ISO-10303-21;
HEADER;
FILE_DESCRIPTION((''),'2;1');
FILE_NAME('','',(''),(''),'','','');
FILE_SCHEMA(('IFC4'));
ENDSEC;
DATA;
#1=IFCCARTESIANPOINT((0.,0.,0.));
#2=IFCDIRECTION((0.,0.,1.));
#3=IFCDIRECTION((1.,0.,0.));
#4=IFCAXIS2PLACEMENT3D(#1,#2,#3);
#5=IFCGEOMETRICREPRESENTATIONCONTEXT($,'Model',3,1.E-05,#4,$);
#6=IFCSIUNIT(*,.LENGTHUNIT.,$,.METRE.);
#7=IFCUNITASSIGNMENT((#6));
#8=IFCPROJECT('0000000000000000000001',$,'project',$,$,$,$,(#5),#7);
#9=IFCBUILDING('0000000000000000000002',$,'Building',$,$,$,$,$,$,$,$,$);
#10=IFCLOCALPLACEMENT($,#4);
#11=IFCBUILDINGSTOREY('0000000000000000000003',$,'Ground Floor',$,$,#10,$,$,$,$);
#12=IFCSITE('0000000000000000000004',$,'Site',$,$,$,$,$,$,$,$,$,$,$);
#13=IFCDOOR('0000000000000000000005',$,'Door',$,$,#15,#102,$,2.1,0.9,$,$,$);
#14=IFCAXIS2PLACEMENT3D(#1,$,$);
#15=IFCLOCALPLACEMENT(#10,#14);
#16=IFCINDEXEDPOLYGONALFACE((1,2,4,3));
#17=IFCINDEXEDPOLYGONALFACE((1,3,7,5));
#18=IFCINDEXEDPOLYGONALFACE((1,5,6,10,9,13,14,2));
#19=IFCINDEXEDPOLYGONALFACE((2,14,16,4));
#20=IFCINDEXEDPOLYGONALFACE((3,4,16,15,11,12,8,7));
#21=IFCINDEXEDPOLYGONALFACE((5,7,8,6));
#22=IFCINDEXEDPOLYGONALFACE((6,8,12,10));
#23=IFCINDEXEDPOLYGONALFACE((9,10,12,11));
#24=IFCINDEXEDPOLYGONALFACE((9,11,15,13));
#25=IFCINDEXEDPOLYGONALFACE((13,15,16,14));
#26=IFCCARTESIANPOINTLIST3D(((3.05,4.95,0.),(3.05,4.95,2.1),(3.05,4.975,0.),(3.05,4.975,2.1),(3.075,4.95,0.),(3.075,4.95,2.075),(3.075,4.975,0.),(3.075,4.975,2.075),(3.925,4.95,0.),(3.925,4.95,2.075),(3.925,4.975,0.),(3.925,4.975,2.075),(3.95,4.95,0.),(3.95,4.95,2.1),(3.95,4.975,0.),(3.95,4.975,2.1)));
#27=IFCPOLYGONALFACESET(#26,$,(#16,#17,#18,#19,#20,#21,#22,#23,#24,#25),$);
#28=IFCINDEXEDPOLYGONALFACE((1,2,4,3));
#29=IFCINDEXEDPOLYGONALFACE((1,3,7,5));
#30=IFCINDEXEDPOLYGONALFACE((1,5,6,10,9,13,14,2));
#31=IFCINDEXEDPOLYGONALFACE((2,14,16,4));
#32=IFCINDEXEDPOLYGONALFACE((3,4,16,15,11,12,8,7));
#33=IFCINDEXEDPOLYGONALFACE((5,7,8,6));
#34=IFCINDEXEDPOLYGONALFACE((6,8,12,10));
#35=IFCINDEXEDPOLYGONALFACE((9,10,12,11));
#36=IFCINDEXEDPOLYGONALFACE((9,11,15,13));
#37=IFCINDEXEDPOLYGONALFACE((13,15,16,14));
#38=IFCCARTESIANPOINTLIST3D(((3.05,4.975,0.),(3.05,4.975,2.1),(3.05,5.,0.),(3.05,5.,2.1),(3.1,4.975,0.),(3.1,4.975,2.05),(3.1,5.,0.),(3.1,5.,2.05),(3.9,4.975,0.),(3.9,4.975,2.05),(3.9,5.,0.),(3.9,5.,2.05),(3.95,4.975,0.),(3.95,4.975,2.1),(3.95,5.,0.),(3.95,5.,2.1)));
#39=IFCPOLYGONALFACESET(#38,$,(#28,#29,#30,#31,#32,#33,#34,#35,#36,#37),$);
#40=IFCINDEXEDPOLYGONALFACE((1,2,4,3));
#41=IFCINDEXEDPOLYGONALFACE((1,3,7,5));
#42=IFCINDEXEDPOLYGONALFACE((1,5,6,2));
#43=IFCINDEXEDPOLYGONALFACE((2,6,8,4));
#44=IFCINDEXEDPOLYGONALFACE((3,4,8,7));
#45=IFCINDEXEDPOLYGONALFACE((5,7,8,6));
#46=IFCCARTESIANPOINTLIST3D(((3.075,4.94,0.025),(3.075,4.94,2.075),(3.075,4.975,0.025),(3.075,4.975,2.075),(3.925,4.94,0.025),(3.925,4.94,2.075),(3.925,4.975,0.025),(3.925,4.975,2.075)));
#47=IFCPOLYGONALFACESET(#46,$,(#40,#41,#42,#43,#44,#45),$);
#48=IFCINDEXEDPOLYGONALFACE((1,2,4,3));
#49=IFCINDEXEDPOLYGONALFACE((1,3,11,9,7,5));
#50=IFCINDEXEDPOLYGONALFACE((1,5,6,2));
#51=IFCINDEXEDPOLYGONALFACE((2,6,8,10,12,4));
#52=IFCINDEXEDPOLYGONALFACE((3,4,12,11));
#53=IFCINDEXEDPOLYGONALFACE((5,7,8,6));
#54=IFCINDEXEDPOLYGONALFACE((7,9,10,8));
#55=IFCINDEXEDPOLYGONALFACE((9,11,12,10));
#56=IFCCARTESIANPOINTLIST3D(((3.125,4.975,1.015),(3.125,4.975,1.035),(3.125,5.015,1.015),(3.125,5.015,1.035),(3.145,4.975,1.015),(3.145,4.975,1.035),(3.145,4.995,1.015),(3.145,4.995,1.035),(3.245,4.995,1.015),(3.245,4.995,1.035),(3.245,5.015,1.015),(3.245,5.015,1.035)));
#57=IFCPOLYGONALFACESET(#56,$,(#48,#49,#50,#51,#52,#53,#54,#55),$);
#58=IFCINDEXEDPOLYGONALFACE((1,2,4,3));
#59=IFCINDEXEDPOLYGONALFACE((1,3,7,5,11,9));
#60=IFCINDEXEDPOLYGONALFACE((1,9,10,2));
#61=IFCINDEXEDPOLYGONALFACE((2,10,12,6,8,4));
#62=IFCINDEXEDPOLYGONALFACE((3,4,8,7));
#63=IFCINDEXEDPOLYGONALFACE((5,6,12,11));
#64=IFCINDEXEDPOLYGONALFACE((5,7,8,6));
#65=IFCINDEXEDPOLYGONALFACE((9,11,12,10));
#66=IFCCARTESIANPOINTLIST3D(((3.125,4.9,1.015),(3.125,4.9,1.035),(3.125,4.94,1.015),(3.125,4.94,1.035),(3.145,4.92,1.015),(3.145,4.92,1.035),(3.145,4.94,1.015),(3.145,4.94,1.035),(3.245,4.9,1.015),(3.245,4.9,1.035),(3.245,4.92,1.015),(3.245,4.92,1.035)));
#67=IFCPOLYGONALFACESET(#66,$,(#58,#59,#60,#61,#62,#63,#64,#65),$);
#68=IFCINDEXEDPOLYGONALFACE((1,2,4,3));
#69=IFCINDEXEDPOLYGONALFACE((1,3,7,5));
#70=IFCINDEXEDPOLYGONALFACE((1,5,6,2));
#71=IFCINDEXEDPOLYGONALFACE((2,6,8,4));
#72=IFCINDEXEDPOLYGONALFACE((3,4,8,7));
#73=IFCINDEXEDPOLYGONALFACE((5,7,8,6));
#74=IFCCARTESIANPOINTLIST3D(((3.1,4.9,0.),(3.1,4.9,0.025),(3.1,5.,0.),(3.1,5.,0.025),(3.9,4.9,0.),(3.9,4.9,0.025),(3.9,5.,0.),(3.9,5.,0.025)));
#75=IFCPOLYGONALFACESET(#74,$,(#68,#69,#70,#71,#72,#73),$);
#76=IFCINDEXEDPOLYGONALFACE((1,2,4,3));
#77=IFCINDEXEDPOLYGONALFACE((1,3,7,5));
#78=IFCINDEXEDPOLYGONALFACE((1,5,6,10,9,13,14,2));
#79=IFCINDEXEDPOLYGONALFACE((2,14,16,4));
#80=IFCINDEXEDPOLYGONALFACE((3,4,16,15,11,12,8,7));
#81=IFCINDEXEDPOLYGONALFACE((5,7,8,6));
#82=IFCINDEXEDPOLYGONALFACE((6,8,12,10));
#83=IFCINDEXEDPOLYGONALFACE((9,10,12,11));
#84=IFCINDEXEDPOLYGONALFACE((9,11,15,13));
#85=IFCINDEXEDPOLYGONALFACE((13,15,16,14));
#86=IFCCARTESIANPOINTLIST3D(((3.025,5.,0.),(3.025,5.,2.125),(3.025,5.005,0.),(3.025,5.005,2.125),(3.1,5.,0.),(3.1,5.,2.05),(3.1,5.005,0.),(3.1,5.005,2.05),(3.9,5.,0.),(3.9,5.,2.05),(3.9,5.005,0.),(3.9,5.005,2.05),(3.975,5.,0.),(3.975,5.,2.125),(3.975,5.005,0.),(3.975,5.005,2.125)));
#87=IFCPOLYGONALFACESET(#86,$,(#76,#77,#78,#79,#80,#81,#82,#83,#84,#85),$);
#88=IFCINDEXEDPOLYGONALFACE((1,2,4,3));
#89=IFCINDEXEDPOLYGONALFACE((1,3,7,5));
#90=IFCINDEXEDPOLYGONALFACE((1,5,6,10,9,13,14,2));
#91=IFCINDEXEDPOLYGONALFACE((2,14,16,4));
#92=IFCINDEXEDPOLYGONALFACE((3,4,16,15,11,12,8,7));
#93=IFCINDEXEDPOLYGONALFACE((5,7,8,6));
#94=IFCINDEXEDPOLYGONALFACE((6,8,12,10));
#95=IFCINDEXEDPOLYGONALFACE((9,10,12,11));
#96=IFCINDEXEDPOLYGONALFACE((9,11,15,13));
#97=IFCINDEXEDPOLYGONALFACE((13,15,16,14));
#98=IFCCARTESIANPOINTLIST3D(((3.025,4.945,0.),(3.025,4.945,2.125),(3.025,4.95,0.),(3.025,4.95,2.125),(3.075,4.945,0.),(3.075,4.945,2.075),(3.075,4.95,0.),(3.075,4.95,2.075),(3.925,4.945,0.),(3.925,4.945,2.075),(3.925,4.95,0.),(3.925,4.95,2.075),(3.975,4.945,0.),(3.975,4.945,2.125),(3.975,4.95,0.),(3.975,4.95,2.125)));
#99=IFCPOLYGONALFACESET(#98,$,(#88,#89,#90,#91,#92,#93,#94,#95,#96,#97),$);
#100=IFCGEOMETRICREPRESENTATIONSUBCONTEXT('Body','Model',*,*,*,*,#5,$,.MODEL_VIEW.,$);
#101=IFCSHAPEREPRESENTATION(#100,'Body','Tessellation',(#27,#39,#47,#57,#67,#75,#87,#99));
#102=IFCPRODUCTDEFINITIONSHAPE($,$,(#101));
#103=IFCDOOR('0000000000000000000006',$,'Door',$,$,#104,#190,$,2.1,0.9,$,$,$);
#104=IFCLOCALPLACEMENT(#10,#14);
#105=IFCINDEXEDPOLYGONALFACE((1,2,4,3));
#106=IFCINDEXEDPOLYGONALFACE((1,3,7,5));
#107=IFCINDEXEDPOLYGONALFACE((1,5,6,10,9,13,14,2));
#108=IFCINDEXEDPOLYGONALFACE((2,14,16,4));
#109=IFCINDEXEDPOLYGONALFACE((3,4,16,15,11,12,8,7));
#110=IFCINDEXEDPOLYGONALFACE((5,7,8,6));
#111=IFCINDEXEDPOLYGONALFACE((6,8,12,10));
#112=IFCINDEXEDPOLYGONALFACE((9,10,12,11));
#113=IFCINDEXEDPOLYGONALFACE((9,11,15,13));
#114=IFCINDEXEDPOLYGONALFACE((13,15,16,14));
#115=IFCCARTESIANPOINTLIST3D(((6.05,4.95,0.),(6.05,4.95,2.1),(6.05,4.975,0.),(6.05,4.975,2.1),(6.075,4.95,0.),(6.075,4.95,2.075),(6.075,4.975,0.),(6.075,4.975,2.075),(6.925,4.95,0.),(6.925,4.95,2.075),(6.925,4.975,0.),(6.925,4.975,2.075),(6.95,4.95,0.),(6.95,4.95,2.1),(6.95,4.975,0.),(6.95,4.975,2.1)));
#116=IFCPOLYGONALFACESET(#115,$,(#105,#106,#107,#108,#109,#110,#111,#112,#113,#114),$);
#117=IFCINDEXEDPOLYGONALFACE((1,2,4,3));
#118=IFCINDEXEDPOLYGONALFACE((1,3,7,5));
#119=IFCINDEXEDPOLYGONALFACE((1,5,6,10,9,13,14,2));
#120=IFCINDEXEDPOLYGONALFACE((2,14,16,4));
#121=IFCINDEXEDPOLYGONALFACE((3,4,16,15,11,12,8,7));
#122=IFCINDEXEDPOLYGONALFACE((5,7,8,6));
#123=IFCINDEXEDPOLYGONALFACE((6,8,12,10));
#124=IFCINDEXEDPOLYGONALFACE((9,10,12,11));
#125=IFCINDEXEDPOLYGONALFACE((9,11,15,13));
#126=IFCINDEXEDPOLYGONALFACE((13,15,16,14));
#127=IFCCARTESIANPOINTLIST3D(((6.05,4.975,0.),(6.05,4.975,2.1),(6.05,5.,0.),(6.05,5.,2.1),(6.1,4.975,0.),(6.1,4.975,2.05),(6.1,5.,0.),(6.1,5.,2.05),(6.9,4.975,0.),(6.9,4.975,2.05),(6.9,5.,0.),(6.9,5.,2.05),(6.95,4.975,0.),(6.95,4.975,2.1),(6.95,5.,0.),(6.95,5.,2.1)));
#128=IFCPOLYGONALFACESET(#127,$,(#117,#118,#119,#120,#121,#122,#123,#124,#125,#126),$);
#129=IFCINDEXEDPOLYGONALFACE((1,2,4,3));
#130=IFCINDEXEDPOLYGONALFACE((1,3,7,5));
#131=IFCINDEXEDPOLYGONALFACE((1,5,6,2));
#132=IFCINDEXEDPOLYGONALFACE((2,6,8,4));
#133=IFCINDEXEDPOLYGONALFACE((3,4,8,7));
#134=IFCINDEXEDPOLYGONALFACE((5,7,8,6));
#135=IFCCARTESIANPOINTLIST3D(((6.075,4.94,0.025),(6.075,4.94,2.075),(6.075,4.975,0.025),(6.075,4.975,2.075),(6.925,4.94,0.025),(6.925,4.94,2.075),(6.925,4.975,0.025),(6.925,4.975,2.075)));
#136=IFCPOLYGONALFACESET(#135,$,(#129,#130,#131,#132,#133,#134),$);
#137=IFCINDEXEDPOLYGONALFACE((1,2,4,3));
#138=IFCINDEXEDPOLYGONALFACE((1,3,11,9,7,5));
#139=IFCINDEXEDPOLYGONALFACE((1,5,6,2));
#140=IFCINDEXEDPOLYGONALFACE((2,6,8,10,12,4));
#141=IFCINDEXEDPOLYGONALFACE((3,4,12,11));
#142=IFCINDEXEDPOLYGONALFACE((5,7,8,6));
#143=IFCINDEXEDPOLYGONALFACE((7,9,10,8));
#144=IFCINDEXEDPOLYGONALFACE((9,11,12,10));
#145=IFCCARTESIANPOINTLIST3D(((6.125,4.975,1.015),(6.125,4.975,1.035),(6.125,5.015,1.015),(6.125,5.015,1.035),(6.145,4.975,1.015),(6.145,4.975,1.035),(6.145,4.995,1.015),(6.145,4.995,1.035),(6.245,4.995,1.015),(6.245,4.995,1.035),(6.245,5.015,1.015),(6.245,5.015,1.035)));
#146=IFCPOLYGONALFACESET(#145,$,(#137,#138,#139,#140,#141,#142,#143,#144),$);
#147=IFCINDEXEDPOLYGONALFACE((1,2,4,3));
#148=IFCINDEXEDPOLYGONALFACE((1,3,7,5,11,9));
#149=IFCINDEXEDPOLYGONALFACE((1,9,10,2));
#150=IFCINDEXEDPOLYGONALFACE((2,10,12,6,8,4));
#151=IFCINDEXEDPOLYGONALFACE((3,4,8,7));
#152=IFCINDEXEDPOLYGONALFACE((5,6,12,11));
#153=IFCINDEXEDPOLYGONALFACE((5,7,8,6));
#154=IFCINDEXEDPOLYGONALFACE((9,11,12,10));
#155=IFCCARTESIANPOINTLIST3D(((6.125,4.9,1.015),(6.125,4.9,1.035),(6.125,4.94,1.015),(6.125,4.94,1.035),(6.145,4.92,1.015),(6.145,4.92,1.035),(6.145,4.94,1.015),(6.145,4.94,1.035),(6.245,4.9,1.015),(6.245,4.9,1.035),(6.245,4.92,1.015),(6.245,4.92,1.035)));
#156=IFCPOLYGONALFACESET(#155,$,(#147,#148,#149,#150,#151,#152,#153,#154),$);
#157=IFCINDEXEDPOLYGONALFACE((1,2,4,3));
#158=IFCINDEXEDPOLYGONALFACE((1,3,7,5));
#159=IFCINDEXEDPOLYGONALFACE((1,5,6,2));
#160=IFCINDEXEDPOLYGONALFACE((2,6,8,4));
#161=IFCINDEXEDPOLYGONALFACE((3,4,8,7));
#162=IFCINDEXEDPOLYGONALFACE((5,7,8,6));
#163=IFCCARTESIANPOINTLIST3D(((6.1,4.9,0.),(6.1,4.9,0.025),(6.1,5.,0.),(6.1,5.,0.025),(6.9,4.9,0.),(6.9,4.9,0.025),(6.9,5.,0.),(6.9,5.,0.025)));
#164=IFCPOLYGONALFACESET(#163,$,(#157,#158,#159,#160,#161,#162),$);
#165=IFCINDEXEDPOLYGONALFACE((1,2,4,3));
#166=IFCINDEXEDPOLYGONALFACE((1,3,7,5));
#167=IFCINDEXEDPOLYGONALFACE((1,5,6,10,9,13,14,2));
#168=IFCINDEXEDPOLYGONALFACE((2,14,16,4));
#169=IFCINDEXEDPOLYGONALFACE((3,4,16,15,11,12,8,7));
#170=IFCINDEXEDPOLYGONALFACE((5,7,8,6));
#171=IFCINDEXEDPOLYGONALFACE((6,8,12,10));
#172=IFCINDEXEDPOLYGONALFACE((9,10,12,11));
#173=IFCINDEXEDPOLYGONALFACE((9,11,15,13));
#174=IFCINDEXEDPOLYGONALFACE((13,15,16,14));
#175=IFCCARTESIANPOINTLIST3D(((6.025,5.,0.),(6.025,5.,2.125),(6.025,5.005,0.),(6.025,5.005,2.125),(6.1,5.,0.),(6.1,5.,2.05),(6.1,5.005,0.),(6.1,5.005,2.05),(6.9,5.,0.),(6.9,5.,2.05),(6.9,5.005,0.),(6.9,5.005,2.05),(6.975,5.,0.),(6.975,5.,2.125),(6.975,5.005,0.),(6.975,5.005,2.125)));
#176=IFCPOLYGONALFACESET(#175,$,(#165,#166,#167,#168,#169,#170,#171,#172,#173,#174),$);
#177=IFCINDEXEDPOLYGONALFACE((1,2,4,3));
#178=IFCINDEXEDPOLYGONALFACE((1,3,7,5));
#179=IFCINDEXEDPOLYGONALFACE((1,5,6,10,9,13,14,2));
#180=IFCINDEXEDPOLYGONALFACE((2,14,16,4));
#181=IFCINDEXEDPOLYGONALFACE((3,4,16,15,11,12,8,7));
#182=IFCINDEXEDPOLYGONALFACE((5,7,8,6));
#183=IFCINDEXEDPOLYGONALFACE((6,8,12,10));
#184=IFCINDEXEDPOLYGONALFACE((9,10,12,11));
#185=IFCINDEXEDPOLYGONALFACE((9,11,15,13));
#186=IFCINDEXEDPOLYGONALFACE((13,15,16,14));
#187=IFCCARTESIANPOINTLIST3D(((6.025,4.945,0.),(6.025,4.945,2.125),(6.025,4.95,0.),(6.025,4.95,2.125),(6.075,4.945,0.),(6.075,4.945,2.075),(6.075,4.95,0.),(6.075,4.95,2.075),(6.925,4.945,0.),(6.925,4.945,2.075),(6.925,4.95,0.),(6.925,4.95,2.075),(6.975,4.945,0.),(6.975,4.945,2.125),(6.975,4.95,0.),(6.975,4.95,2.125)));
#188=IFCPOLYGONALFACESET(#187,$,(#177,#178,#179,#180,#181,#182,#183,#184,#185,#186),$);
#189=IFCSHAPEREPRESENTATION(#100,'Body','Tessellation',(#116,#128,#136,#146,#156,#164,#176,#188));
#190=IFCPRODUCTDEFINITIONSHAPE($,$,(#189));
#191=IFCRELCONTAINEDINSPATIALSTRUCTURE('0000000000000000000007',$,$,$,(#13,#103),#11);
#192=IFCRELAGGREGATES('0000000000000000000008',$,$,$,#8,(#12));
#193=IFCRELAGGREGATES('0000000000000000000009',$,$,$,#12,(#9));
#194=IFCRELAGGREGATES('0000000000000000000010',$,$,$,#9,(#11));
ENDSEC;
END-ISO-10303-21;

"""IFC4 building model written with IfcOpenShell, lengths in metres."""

from ifc_helpers import new_model, si_unit, frame, origin_with_axes, place, context, subcontext, project, spatial, line, indexed_curve, outline, extrude, element, save


model = new_model("IFC4")

# Units and contexts
model_context = context("Model", 3, precision=1e-05, world=origin_with_axes())
body_context = subcontext(model_context, "Body", "Model", "MODEL_VIEW")
ifc_project = project(units=[si_unit("LENGTHUNIT", "METRE")], contexts=[model_context])

# Site, building, storey
site = spatial("IfcSite", under=ifc_project, Name="Site")
building = spatial("IfcBuilding", under=site, Name="Building")
storey_placement = place(None, origin_with_axes())
storey = spatial("IfcBuildingStorey", under=building, at=storey_placement, Name="Ground Floor")

# Doors
door_1_placement = place(storey_placement, frame((3.95, 5.0, 0.0), z_axis=(0.0, 0.0, 1.0), x_axis=(-1.0, 0.0, 0.0)))
element("IfcDoor", 1, at=door_1_placement, inside=storey, Name="Door", OverallHeight=2.1, OverallWidth=0.9, context=body_context, shape_type="SweptSolid", body=[
    extrude(outline(indexed_curve([(0.0, 0.0), (0.0, 2.1), (0.9, 2.1), (0.9, 0.0), (0.875, 0.0), (0.875, 2.075), (0.025, 2.075), (0.025, 0.0)], segments=[line(1, 2, 3, 4, 5, 6, 7, 8, 1)])), frame((0.0, 0.025, 0.0), z_axis=(0.0, -1.0, 0.0), x_axis=(1.0, 0.0, 0.0)), (0.0, 0.0, -1.0), 0.025),
    extrude(outline(indexed_curve([(0.0, 0.0), (0.0, 2.1), (0.9, 2.1), (0.9, 0.0), (0.85, 0.0), (0.85, 2.05), (0.05, 2.05), (0.05, 0.0)], segments=[line(1, 2, 3, 4, 5, 6, 7, 8, 1)])), frame((0.0, 0.0, 0.0), z_axis=(0.0, -1.0, 0.0), x_axis=(1.0, 0.0, 0.0)), (0.0, 0.0, -1.0), 0.025),
    extrude(outline(indexed_curve([(0.0, 0.0), (0.85, 0.0), (0.85, 0.035), (0.0, 0.035)], segments=[line(1, 2, 3, 4, 1)])), frame((0.025, 0.025, 0.025), z_axis=(0.0, 0.0, 1.0), x_axis=(1.0, 0.0, 0.0)), (0.0, 0.0, 1.0), 2.05),
    extrude(outline(indexed_curve([(0.0, 0.0), (0.0, -0.04), (-0.12, -0.04), (-0.12, -0.02), (-0.02, -0.02), (-0.02, 0.0)], segments=[line(1, 2, 3, 4, 5, 6, 1)])), frame((0.825, 0.025, 1.015), z_axis=(0.0, 0.0, 1.0), x_axis=(1.0, 0.0, 0.0)), (0.0, 0.0, 1.0), 0.02),
    extrude(outline(indexed_curve([(0.0, 0.0), (0.0, 0.04), (-0.12, 0.04), (-0.12, 0.02), (-0.02, 0.02), (-0.02, 0.0)], segments=[line(1, 2, 3, 4, 5, 6, 1)])), frame((0.825, 0.06, 1.015), z_axis=(0.0, 0.0, 1.0), x_axis=(1.0, 0.0, 0.0)), (0.0, 0.0, 1.0), 0.02),
    extrude(outline(indexed_curve([(0.0, 0.0), (0.8, 0.0), (0.8, 0.1), (0.0, 0.1)], segments=[line(1, 2, 3, 4, 1)])), frame((0.05, 0.0, 0.0), z_axis=(0.0, 0.0, 1.0), x_axis=(1.0, 0.0, 0.0)), (0.0, 0.0, 1.0), 0.025),
    extrude(outline(indexed_curve([(0.0, 0.0), (0.0, 2.125), (0.95, 2.125), (0.95, 0.0), (0.875, 0.0), (0.875, 2.05), (0.075, 2.05), (0.075, 0.0)], segments=[line(1, 2, 3, 4, 5, 6, 7, 8, 1)])), frame((-0.025, -0.005, 0.0), z_axis=(0.0, -1.0, 0.0), x_axis=(1.0, 0.0, 0.0)), (0.0, 0.0, -1.0), 0.005),
    extrude(outline(indexed_curve([(0.0, 0.0), (0.0, 2.125), (0.95, 2.125), (0.95, 0.0), (0.9, 0.0), (0.9, 2.075), (0.05, 2.075), (0.05, 0.0)], segments=[line(1, 2, 3, 4, 5, 6, 7, 8, 1)])), frame((-0.025, 0.05, 0.0), z_axis=(0.0, -1.0, 0.0), x_axis=(1.0, 0.0, 0.0)), (0.0, 0.0, -1.0), 0.005),
])
door_2_placement = place(storey_placement, frame((6.95, 5.0, 0.0), z_axis=(0.0, 0.0, 1.0), x_axis=(-1.0, 0.0, 0.0)))
element("IfcDoor", 2, at=door_2_placement, inside=storey, Name="Door", OverallHeight=2.1, OverallWidth=0.9, context=body_context, shape_type="SweptSolid", body=[
    extrude(outline(indexed_curve([(0.0, 0.0), (0.0, 2.1), (0.9, 2.1), (0.9, 0.0), (0.875, 0.0), (0.875, 2.075), (0.025, 2.075), (0.025, 0.0)], segments=[line(1, 2, 3, 4, 5, 6, 7, 8, 1)])), frame((0.0, 0.025, 0.0), z_axis=(0.0, -1.0, 0.0), x_axis=(1.0, 0.0, 0.0)), (0.0, 0.0, -1.0), 0.025),
    extrude(outline(indexed_curve([(0.0, 0.0), (0.0, 2.1), (0.9, 2.1), (0.9, 0.0), (0.85, 0.0), (0.85, 2.05), (0.05, 2.05), (0.05, 0.0)], segments=[line(1, 2, 3, 4, 5, 6, 7, 8, 1)])), frame((0.0, 0.0, 0.0), z_axis=(0.0, -1.0, 0.0), x_axis=(1.0, 0.0, 0.0)), (0.0, 0.0, -1.0), 0.025),
    extrude(outline(indexed_curve([(0.0, 0.0), (0.85, 0.0), (0.85, 0.035), (0.0, 0.035)], segments=[line(1, 2, 3, 4, 1)])), frame((0.025, 0.025, 0.025), z_axis=(0.0, 0.0, 1.0), x_axis=(1.0, 0.0, 0.0)), (0.0, 0.0, 1.0), 2.05),
    extrude(outline(indexed_curve([(0.0, 0.0), (0.0, -0.04), (-0.12, -0.04), (-0.12, -0.02), (-0.02, -0.02), (-0.02, 0.0)], segments=[line(1, 2, 3, 4, 5, 6, 1)])), frame((0.825, 0.025, 1.015), z_axis=(0.0, 0.0, 1.0), x_axis=(1.0, 0.0, 0.0)), (0.0, 0.0, 1.0), 0.02),
    extrude(outline(indexed_curve([(0.0, 0.0), (0.0, 0.04), (-0.12, 0.04), (-0.12, 0.02), (-0.02, 0.02), (-0.02, 0.0)], segments=[line(1, 2, 3, 4, 5, 6, 1)])), frame((0.825, 0.06, 1.015), z_axis=(0.0, 0.0, 1.0), x_axis=(1.0, 0.0, 0.0)), (0.0, 0.0, 1.0), 0.02),
    extrude(outline(indexed_curve([(0.0, 0.0), (0.8, 0.0), (0.8, 0.1), (0.0, 0.1)], segments=[line(1, 2, 3, 4, 1)])), frame((0.05, 0.0, 0.0), z_axis=(0.0, 0.0, 1.0), x_axis=(1.0, 0.0, 0.0)), (0.0, 0.0, 1.0), 0.025),
    extrude(outline(indexed_curve([(0.0, 0.0), (0.0, 2.125), (0.95, 2.125), (0.95, 0.0), (0.875, 0.0), (0.875, 2.05), (0.075, 2.05), (0.075, 0.0)], segments=[line(1, 2, 3, 4, 5, 6, 7, 8, 1)])), frame((-0.025, -0.005, 0.0), z_axis=(0.0, -1.0, 0.0), x_axis=(1.0, 0.0, 0.0)), (0.0, 0.0, -1.0), 0.005),
    extrude(outline(indexed_curve([(0.0, 0.0), (0.0, 2.125), (0.95, 2.125), (0.95, 0.0), (0.9, 0.0), (0.9, 2.075), (0.05, 2.075), (0.05, 0.0)], segments=[line(1, 2, 3, 4, 5, 6, 7, 8, 1)])), frame((-0.025, 0.05, 0.0), z_axis=(0.0, -1.0, 0.0), x_axis=(1.0, 0.0, 0.0)), (0.0, 0.0, -1.0), 0.005),
])

save(model, "model.ifc")
